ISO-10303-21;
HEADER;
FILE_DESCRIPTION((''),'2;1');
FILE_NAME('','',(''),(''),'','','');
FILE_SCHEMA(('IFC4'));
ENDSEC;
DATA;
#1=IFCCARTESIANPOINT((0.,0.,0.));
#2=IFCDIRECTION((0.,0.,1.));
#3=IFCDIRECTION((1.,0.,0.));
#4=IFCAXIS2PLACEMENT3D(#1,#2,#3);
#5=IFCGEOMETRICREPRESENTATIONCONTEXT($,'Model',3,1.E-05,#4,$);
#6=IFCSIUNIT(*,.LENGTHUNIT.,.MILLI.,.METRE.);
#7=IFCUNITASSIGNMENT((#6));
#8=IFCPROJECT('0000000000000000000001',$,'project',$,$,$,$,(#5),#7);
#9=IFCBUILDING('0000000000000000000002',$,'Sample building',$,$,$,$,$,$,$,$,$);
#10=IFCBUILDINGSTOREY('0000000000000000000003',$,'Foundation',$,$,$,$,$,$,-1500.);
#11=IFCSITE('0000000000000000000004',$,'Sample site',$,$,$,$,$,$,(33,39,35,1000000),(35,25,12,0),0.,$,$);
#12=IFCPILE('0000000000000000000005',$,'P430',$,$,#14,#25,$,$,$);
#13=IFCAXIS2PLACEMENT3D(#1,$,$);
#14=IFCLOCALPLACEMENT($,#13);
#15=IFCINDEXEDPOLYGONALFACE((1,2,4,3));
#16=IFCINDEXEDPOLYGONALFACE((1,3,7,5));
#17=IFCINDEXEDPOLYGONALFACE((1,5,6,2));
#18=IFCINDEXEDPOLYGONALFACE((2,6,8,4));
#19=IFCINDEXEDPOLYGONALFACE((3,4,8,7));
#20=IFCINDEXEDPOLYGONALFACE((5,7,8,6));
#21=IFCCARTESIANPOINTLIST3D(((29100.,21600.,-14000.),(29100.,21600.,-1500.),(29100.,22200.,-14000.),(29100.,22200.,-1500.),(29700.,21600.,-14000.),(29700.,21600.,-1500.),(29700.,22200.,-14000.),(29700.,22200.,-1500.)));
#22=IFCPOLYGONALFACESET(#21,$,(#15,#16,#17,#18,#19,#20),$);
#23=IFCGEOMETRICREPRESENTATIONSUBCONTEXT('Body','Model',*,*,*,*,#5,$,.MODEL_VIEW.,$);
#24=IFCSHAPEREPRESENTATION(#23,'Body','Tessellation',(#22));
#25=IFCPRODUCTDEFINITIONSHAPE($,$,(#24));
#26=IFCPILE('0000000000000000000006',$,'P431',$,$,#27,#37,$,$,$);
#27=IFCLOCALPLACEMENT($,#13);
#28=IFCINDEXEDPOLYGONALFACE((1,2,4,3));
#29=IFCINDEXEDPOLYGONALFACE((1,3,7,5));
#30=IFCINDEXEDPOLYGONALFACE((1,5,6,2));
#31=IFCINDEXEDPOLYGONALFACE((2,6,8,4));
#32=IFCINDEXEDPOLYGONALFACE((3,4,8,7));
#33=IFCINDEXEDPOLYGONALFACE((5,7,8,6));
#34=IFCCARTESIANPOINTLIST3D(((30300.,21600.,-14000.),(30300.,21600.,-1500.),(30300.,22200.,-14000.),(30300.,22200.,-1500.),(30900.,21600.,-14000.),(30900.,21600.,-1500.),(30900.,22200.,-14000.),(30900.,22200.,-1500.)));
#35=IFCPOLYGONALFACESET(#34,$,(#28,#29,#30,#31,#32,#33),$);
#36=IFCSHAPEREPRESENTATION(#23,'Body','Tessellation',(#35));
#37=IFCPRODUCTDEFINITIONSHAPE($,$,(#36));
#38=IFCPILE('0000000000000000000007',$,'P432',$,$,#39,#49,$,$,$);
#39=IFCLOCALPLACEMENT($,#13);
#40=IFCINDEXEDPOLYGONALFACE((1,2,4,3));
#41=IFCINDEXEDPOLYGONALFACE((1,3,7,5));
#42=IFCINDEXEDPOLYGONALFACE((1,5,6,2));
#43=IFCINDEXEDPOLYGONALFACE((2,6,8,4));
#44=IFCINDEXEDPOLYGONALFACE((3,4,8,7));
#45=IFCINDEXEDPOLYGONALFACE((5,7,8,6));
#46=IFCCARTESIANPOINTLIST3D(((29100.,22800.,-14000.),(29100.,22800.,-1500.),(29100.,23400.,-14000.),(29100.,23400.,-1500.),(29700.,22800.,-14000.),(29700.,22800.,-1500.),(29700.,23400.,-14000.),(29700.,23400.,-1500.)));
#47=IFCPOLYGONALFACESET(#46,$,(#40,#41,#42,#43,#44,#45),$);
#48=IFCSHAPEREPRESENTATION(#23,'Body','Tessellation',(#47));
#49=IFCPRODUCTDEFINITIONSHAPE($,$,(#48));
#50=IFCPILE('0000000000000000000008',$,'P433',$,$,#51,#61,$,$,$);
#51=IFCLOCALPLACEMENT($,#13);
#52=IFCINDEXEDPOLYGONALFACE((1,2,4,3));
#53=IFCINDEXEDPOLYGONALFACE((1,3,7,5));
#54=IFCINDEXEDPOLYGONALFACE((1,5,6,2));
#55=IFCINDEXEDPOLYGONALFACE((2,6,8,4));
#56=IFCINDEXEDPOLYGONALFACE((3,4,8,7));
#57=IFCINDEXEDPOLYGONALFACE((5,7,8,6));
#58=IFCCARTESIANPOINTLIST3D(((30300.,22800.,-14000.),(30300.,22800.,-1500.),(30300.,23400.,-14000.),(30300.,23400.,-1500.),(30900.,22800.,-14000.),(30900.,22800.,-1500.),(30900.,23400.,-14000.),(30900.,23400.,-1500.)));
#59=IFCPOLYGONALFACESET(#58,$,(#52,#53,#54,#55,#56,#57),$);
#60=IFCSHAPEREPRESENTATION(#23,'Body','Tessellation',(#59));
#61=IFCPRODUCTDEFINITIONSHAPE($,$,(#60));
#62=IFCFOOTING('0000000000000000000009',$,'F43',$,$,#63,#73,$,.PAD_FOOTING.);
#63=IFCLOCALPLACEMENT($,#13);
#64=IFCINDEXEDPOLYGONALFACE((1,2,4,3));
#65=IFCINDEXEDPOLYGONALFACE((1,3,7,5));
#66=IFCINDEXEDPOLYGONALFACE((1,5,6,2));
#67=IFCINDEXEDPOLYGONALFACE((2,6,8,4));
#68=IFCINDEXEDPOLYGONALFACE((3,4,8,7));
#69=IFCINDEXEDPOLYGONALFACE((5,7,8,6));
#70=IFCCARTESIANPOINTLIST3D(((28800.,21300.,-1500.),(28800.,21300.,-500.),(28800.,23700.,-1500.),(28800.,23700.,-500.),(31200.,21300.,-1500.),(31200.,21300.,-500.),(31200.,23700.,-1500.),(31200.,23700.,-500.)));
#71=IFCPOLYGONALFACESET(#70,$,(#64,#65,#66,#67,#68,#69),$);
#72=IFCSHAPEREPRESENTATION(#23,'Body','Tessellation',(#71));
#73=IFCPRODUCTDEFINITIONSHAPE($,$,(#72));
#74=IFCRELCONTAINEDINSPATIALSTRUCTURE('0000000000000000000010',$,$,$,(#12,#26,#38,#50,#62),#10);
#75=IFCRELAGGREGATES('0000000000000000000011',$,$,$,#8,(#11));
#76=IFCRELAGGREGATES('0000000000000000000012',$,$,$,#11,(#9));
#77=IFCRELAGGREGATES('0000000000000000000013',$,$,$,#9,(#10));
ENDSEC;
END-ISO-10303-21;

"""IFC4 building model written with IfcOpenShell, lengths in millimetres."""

from ifc_helpers import new_model, si_unit, frame, origin_with_axes, place, context, subcontext, project, spatial, indexed_curve, outline, extrude, element, save


model = new_model("IFC4")

# Units and contexts
model_context = context("Model", 3, precision=1e-05, world=origin_with_axes())
body_context = subcontext(model_context, "Body", "Model", "MODEL_VIEW")
ifc_project = project(units=[si_unit("LENGTHUNIT", "METRE", prefix="MILLI")], contexts=[model_context])

# Site, building, storey
site = spatial("IfcSite", under=ifc_project, Name="Sample site", RefLatitude=(33, 39, 35, 1000000), RefLongitude=(35, 25, 12, 0), RefElevation=0.0)
building = spatial("IfcBuilding", under=site, Name="Sample building")
storey = spatial("IfcBuildingStorey", under=building, Name="Foundation", Elevation=-1500.0)

# Piles
for number, where, z_axis, x_axis, name in (
    (1, (29100.0, 21600.0, -14000.0), (0.0, 0.0, 1.0), (1.0, 0.0, 0.0), "P430"),
    (2, (30300.0, 21600.0, -14000.0), (0.0, 0.0, 1.0), (1.0, 0.0, 0.0), "P431"),
    (3, (29100.0, 22800.0, -14000.0), (0.0, 0.0, 1.0), (1.0, 0.0, 0.0), "P432"),
    (4, (30300.0, 22800.0, -14000.0), (0.0, 0.0, 1.0), (1.0, 0.0, 0.0), "P433"),
):
    element("IfcPile", number, at=place(None, frame(where, z_axis=z_axis, x_axis=x_axis)), inside=storey, Name=name, context=body_context, shape_type="SweptSolid", body=[
        extrude(outline(indexed_curve([(0.0, 0.0), (0.0, 600.0), (600.0, 600.0), (600.0, 0.0), (0.0, 0.0)], self_intersect=False)), origin_with_axes(), (0.0, 0.0, 1.0), 12500.0),
    ])

# Footing
footing_1_placement = place(None, frame((28800.0, 21300.0, -1500.0), z_axis=(0.0, 0.0, 1.0), x_axis=(1.0, 0.0, 0.0)))
element("IfcFooting", 5, at=footing_1_placement, inside=storey, Name="F43", PredefinedType="PAD_FOOTING", context=body_context, shape_type="SweptSolid", body=[
    extrude(outline(indexed_curve([(0.0, 0.0), (0.0, 2400.0), (2400.0, 2400.0), (2400.0, 0.0), (0.0, 0.0)], self_intersect=False)), origin_with_axes(), (0.0, 0.0, 1.0), 1000.0),
])

save(model, "model.ifc")
